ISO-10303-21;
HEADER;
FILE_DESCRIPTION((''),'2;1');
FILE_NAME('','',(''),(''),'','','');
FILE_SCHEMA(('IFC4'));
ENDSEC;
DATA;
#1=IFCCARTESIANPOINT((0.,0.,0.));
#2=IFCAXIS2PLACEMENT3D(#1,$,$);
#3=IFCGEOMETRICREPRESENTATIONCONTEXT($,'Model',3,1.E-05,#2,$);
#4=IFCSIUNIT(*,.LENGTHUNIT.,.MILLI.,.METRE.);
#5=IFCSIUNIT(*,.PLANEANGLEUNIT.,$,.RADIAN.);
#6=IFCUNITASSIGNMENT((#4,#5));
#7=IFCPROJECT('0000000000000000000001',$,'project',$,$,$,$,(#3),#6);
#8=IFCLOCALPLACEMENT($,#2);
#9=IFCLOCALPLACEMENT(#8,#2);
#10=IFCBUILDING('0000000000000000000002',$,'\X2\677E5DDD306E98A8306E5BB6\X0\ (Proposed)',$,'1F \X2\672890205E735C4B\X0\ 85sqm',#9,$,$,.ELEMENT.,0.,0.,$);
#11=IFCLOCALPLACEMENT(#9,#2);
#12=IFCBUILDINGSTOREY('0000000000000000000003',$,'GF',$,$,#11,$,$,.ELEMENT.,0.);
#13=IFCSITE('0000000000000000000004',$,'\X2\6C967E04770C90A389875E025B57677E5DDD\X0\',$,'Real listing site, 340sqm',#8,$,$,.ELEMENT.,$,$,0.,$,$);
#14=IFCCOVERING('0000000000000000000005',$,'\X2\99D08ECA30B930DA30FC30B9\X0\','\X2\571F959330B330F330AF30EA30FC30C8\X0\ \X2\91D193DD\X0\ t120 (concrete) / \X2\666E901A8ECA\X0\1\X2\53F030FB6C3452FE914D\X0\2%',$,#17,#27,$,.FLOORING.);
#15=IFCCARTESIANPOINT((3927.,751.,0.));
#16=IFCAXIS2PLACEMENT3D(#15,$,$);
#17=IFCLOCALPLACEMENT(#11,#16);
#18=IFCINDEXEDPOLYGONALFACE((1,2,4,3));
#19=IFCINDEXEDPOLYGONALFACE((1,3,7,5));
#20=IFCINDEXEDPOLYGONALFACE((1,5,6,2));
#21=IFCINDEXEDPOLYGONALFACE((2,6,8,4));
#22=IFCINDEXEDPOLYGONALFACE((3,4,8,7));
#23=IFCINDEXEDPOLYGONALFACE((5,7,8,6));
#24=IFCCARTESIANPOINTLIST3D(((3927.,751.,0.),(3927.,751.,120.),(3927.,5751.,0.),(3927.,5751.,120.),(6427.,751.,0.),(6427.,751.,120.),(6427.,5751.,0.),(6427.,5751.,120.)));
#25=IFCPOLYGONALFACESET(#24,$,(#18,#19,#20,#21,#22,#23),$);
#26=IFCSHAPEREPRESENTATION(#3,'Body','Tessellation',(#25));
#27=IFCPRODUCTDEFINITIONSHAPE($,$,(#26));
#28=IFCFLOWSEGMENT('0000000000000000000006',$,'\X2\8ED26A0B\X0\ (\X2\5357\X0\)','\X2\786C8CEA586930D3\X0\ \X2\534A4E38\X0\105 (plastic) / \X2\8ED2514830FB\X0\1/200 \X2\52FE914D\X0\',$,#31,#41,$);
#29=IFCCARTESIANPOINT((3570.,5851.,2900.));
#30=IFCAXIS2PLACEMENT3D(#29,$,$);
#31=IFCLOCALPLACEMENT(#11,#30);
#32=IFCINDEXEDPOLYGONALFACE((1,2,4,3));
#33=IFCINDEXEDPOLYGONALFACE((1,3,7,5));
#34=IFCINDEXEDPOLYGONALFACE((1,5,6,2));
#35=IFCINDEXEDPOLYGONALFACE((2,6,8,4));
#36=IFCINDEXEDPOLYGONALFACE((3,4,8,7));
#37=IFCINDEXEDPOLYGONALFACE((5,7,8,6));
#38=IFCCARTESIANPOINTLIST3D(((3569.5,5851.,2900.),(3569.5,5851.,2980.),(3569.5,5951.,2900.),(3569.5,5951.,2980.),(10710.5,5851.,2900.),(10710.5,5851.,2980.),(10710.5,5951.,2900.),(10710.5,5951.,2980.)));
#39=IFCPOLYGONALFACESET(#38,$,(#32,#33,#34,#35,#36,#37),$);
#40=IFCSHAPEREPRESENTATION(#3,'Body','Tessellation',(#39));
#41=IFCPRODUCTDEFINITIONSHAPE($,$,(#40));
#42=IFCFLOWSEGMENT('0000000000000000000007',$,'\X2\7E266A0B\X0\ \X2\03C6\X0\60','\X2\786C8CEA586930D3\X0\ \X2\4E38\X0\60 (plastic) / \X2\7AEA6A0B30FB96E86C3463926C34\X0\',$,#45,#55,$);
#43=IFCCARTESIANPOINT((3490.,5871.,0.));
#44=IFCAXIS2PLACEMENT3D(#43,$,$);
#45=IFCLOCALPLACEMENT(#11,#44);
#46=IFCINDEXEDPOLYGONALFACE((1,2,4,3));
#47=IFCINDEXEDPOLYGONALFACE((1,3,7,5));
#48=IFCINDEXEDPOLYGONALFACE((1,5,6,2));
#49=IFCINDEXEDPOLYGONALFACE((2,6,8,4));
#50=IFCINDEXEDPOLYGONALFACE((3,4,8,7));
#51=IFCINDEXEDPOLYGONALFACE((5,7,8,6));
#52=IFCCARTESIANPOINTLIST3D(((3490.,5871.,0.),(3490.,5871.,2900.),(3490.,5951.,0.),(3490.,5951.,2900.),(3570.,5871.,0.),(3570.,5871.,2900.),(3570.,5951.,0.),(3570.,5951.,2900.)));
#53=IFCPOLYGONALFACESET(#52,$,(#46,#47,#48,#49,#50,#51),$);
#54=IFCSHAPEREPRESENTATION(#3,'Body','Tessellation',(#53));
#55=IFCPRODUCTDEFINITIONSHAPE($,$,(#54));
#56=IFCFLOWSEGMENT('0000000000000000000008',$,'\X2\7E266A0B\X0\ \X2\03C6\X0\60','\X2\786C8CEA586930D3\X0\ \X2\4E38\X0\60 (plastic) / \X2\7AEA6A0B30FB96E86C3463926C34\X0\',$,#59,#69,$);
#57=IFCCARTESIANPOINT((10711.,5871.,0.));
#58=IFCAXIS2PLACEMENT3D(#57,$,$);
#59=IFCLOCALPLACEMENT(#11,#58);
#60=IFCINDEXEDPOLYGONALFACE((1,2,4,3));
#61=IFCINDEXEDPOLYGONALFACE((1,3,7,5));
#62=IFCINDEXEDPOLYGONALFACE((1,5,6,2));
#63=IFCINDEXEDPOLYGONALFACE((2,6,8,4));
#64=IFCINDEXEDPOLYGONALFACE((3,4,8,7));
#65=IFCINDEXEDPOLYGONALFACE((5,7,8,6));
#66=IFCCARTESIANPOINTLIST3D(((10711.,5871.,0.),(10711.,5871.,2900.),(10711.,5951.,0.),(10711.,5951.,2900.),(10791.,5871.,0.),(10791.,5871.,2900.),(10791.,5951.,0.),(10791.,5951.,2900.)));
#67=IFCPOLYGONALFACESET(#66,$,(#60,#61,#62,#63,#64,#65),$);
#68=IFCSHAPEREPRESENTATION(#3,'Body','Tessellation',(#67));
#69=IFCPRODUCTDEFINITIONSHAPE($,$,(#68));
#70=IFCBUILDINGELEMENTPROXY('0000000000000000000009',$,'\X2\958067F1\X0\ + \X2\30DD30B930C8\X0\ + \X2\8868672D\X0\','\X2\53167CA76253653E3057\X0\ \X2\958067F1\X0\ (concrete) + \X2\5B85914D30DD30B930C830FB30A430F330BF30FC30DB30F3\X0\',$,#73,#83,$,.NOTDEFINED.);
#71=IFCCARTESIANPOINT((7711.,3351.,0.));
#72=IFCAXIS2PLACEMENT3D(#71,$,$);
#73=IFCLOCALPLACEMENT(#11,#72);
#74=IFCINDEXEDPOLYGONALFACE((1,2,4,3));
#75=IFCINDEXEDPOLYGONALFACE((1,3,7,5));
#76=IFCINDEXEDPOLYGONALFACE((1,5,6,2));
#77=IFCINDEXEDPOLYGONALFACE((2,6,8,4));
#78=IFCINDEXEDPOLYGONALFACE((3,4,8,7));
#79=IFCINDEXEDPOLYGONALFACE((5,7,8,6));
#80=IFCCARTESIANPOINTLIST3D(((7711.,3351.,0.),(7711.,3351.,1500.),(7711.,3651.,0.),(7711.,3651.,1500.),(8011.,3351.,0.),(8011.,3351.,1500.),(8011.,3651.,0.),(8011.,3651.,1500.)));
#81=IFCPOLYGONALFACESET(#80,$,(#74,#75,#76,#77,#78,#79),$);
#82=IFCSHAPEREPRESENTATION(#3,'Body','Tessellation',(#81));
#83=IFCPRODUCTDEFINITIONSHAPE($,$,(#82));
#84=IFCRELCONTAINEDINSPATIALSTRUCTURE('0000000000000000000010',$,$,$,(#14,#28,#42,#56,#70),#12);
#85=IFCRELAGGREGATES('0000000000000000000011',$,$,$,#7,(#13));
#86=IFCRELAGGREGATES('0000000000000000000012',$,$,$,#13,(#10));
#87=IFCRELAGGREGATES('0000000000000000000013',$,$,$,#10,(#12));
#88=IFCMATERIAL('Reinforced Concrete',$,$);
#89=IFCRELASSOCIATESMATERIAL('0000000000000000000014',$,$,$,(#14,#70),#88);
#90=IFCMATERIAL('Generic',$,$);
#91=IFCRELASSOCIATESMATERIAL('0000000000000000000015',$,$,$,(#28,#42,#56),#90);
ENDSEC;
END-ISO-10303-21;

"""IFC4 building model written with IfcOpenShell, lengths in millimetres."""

from ifc_helpers import new_model, si_unit, frame, frame_2d, origin, place, context, project, spatial, rectangle, extrude, material, element, save


model = new_model("IFC4")

# Units and contexts
model_context = context("Model", 3, precision=1e-05, world=origin())
ifc_project = project(units=[si_unit("LENGTHUNIT", "METRE", prefix="MILLI"), si_unit("PLANEANGLEUNIT", "RADIAN")], contexts=[model_context])

# Site, building, storey
site_placement = place(None, origin())
site = spatial("IfcSite", under=ifc_project, at=site_placement, Name="沖縄県那覇市字松川", ObjectType="Real listing site, 340sqm", CompositionType="ELEMENT", RefElevation=0.0)
building_placement = place(site_placement, origin())
building = spatial("IfcBuilding", under=site, at=building_placement, Name="松川の風の家 (Proposed)", ObjectType="1F 木造平屋 85sqm", CompositionType="ELEMENT", ElevationOfRefHeight=0.0, ElevationOfTerrain=0.0)
storey_placement = place(building_placement, origin())
storey = spatial("IfcBuildingStorey", under=building, at=storey_placement, Name="GF", CompositionType="ELEMENT", Elevation=0.0)

# Shared definitions
ifc_material_1 = material(Name="Reinforced Concrete")

# Covering
covering_1_placement = place(storey_placement, frame((3927.0, 751.0, 0.0)))
element("IfcCovering", 1, at=covering_1_placement, inside=storey, material=ifc_material_1, Name="駐車スペース", Description="土間コンクリート 金鏝 t120 (concrete) / 普通車1台・水勾配2%", PredefinedType="FLOORING", context=model_context, shape_type="SweptSolid", body=[
    extrude(rectangle(XDim=2500.0, YDim=5000.0, at=frame_2d((1250.0, 2500.0))), frame((3927.0, 751.0, 0.0)), (0.0, 0.0, 1.0), 120.0),
])

# Flow segments
ifc_material_2 = material(Name="Generic")
flow_segment_1_placement = place(storey_placement, frame((3570.0, 5851.0, 2900.0)))
element("IfcFlowSegment", 2, at=flow_segment_1_placement, inside=storey, material=ifc_material_2, Name="軒樋 (南)", Description="硬質塩ビ 半丸105 (plastic) / 軒先・1/200 勾配", context=model_context, shape_type="SweptSolid", body=[
    extrude(rectangle(XDim=7141.0, YDim=100.0, at=frame_2d((3570.0, 50.0))), frame((3570.0, 5851.0, 2900.0)), (0.0, 0.0, 1.0), 80.0),
])
flow_segment_2_placement = place(storey_placement, frame((3490.0, 5871.0, 0.0)))
element("IfcFlowSegment", 3, at=flow_segment_2_placement, inside=storey, material=ifc_material_2, Name="縦樋 φ60", Description="硬質塩ビ 丸60 (plastic) / 竪樋・雨水排水", context=model_context, shape_type="SweptSolid", body=[
    extrude(rectangle(XDim=80.0, YDim=80.0, at=frame_2d((40.0, 40.0))), frame((3490.0, 5871.0, 0.0)), (0.0, 0.0, 1.0), 2900.0),
])
flow_segment_3_placement = place(storey_placement, frame((10711.0, 5871.0, 0.0)))
element("IfcFlowSegment", 4, at=flow_segment_3_placement, inside=storey, material=ifc_material_2, Name="縦樋 φ60", Description="硬質塩ビ 丸60 (plastic) / 竪樋・雨水排水", context=model_context, shape_type="SweptSolid", body=[
    extrude(rectangle(XDim=80.0, YDim=80.0, at=frame_2d((40.0, 40.0))), frame((10711.0, 5871.0, 0.0)), (0.0, 0.0, 1.0), 2900.0),
])

# Building element proxy
proxy_placement = place(storey_placement, frame((7711.0, 3351.0, 0.0)))
element("IfcBuildingElementProxy", 5, at=proxy_placement, inside=storey, material=ifc_material_1, Name="門柱 + ポスト + 表札", Description="化粧打放し 門柱 (concrete) + 宅配ポスト・インターホン", PredefinedType="NOTDEFINED", context=model_context, shape_type="SweptSolid", body=[
    extrude(rectangle(XDim=300.0, YDim=300.0, at=frame_2d((150.0, 150.0))), frame((7711.0, 3351.0, 0.0)), (0.0, 0.0, 1.0), 1500.0),
])

save(model, "model.ifc")
